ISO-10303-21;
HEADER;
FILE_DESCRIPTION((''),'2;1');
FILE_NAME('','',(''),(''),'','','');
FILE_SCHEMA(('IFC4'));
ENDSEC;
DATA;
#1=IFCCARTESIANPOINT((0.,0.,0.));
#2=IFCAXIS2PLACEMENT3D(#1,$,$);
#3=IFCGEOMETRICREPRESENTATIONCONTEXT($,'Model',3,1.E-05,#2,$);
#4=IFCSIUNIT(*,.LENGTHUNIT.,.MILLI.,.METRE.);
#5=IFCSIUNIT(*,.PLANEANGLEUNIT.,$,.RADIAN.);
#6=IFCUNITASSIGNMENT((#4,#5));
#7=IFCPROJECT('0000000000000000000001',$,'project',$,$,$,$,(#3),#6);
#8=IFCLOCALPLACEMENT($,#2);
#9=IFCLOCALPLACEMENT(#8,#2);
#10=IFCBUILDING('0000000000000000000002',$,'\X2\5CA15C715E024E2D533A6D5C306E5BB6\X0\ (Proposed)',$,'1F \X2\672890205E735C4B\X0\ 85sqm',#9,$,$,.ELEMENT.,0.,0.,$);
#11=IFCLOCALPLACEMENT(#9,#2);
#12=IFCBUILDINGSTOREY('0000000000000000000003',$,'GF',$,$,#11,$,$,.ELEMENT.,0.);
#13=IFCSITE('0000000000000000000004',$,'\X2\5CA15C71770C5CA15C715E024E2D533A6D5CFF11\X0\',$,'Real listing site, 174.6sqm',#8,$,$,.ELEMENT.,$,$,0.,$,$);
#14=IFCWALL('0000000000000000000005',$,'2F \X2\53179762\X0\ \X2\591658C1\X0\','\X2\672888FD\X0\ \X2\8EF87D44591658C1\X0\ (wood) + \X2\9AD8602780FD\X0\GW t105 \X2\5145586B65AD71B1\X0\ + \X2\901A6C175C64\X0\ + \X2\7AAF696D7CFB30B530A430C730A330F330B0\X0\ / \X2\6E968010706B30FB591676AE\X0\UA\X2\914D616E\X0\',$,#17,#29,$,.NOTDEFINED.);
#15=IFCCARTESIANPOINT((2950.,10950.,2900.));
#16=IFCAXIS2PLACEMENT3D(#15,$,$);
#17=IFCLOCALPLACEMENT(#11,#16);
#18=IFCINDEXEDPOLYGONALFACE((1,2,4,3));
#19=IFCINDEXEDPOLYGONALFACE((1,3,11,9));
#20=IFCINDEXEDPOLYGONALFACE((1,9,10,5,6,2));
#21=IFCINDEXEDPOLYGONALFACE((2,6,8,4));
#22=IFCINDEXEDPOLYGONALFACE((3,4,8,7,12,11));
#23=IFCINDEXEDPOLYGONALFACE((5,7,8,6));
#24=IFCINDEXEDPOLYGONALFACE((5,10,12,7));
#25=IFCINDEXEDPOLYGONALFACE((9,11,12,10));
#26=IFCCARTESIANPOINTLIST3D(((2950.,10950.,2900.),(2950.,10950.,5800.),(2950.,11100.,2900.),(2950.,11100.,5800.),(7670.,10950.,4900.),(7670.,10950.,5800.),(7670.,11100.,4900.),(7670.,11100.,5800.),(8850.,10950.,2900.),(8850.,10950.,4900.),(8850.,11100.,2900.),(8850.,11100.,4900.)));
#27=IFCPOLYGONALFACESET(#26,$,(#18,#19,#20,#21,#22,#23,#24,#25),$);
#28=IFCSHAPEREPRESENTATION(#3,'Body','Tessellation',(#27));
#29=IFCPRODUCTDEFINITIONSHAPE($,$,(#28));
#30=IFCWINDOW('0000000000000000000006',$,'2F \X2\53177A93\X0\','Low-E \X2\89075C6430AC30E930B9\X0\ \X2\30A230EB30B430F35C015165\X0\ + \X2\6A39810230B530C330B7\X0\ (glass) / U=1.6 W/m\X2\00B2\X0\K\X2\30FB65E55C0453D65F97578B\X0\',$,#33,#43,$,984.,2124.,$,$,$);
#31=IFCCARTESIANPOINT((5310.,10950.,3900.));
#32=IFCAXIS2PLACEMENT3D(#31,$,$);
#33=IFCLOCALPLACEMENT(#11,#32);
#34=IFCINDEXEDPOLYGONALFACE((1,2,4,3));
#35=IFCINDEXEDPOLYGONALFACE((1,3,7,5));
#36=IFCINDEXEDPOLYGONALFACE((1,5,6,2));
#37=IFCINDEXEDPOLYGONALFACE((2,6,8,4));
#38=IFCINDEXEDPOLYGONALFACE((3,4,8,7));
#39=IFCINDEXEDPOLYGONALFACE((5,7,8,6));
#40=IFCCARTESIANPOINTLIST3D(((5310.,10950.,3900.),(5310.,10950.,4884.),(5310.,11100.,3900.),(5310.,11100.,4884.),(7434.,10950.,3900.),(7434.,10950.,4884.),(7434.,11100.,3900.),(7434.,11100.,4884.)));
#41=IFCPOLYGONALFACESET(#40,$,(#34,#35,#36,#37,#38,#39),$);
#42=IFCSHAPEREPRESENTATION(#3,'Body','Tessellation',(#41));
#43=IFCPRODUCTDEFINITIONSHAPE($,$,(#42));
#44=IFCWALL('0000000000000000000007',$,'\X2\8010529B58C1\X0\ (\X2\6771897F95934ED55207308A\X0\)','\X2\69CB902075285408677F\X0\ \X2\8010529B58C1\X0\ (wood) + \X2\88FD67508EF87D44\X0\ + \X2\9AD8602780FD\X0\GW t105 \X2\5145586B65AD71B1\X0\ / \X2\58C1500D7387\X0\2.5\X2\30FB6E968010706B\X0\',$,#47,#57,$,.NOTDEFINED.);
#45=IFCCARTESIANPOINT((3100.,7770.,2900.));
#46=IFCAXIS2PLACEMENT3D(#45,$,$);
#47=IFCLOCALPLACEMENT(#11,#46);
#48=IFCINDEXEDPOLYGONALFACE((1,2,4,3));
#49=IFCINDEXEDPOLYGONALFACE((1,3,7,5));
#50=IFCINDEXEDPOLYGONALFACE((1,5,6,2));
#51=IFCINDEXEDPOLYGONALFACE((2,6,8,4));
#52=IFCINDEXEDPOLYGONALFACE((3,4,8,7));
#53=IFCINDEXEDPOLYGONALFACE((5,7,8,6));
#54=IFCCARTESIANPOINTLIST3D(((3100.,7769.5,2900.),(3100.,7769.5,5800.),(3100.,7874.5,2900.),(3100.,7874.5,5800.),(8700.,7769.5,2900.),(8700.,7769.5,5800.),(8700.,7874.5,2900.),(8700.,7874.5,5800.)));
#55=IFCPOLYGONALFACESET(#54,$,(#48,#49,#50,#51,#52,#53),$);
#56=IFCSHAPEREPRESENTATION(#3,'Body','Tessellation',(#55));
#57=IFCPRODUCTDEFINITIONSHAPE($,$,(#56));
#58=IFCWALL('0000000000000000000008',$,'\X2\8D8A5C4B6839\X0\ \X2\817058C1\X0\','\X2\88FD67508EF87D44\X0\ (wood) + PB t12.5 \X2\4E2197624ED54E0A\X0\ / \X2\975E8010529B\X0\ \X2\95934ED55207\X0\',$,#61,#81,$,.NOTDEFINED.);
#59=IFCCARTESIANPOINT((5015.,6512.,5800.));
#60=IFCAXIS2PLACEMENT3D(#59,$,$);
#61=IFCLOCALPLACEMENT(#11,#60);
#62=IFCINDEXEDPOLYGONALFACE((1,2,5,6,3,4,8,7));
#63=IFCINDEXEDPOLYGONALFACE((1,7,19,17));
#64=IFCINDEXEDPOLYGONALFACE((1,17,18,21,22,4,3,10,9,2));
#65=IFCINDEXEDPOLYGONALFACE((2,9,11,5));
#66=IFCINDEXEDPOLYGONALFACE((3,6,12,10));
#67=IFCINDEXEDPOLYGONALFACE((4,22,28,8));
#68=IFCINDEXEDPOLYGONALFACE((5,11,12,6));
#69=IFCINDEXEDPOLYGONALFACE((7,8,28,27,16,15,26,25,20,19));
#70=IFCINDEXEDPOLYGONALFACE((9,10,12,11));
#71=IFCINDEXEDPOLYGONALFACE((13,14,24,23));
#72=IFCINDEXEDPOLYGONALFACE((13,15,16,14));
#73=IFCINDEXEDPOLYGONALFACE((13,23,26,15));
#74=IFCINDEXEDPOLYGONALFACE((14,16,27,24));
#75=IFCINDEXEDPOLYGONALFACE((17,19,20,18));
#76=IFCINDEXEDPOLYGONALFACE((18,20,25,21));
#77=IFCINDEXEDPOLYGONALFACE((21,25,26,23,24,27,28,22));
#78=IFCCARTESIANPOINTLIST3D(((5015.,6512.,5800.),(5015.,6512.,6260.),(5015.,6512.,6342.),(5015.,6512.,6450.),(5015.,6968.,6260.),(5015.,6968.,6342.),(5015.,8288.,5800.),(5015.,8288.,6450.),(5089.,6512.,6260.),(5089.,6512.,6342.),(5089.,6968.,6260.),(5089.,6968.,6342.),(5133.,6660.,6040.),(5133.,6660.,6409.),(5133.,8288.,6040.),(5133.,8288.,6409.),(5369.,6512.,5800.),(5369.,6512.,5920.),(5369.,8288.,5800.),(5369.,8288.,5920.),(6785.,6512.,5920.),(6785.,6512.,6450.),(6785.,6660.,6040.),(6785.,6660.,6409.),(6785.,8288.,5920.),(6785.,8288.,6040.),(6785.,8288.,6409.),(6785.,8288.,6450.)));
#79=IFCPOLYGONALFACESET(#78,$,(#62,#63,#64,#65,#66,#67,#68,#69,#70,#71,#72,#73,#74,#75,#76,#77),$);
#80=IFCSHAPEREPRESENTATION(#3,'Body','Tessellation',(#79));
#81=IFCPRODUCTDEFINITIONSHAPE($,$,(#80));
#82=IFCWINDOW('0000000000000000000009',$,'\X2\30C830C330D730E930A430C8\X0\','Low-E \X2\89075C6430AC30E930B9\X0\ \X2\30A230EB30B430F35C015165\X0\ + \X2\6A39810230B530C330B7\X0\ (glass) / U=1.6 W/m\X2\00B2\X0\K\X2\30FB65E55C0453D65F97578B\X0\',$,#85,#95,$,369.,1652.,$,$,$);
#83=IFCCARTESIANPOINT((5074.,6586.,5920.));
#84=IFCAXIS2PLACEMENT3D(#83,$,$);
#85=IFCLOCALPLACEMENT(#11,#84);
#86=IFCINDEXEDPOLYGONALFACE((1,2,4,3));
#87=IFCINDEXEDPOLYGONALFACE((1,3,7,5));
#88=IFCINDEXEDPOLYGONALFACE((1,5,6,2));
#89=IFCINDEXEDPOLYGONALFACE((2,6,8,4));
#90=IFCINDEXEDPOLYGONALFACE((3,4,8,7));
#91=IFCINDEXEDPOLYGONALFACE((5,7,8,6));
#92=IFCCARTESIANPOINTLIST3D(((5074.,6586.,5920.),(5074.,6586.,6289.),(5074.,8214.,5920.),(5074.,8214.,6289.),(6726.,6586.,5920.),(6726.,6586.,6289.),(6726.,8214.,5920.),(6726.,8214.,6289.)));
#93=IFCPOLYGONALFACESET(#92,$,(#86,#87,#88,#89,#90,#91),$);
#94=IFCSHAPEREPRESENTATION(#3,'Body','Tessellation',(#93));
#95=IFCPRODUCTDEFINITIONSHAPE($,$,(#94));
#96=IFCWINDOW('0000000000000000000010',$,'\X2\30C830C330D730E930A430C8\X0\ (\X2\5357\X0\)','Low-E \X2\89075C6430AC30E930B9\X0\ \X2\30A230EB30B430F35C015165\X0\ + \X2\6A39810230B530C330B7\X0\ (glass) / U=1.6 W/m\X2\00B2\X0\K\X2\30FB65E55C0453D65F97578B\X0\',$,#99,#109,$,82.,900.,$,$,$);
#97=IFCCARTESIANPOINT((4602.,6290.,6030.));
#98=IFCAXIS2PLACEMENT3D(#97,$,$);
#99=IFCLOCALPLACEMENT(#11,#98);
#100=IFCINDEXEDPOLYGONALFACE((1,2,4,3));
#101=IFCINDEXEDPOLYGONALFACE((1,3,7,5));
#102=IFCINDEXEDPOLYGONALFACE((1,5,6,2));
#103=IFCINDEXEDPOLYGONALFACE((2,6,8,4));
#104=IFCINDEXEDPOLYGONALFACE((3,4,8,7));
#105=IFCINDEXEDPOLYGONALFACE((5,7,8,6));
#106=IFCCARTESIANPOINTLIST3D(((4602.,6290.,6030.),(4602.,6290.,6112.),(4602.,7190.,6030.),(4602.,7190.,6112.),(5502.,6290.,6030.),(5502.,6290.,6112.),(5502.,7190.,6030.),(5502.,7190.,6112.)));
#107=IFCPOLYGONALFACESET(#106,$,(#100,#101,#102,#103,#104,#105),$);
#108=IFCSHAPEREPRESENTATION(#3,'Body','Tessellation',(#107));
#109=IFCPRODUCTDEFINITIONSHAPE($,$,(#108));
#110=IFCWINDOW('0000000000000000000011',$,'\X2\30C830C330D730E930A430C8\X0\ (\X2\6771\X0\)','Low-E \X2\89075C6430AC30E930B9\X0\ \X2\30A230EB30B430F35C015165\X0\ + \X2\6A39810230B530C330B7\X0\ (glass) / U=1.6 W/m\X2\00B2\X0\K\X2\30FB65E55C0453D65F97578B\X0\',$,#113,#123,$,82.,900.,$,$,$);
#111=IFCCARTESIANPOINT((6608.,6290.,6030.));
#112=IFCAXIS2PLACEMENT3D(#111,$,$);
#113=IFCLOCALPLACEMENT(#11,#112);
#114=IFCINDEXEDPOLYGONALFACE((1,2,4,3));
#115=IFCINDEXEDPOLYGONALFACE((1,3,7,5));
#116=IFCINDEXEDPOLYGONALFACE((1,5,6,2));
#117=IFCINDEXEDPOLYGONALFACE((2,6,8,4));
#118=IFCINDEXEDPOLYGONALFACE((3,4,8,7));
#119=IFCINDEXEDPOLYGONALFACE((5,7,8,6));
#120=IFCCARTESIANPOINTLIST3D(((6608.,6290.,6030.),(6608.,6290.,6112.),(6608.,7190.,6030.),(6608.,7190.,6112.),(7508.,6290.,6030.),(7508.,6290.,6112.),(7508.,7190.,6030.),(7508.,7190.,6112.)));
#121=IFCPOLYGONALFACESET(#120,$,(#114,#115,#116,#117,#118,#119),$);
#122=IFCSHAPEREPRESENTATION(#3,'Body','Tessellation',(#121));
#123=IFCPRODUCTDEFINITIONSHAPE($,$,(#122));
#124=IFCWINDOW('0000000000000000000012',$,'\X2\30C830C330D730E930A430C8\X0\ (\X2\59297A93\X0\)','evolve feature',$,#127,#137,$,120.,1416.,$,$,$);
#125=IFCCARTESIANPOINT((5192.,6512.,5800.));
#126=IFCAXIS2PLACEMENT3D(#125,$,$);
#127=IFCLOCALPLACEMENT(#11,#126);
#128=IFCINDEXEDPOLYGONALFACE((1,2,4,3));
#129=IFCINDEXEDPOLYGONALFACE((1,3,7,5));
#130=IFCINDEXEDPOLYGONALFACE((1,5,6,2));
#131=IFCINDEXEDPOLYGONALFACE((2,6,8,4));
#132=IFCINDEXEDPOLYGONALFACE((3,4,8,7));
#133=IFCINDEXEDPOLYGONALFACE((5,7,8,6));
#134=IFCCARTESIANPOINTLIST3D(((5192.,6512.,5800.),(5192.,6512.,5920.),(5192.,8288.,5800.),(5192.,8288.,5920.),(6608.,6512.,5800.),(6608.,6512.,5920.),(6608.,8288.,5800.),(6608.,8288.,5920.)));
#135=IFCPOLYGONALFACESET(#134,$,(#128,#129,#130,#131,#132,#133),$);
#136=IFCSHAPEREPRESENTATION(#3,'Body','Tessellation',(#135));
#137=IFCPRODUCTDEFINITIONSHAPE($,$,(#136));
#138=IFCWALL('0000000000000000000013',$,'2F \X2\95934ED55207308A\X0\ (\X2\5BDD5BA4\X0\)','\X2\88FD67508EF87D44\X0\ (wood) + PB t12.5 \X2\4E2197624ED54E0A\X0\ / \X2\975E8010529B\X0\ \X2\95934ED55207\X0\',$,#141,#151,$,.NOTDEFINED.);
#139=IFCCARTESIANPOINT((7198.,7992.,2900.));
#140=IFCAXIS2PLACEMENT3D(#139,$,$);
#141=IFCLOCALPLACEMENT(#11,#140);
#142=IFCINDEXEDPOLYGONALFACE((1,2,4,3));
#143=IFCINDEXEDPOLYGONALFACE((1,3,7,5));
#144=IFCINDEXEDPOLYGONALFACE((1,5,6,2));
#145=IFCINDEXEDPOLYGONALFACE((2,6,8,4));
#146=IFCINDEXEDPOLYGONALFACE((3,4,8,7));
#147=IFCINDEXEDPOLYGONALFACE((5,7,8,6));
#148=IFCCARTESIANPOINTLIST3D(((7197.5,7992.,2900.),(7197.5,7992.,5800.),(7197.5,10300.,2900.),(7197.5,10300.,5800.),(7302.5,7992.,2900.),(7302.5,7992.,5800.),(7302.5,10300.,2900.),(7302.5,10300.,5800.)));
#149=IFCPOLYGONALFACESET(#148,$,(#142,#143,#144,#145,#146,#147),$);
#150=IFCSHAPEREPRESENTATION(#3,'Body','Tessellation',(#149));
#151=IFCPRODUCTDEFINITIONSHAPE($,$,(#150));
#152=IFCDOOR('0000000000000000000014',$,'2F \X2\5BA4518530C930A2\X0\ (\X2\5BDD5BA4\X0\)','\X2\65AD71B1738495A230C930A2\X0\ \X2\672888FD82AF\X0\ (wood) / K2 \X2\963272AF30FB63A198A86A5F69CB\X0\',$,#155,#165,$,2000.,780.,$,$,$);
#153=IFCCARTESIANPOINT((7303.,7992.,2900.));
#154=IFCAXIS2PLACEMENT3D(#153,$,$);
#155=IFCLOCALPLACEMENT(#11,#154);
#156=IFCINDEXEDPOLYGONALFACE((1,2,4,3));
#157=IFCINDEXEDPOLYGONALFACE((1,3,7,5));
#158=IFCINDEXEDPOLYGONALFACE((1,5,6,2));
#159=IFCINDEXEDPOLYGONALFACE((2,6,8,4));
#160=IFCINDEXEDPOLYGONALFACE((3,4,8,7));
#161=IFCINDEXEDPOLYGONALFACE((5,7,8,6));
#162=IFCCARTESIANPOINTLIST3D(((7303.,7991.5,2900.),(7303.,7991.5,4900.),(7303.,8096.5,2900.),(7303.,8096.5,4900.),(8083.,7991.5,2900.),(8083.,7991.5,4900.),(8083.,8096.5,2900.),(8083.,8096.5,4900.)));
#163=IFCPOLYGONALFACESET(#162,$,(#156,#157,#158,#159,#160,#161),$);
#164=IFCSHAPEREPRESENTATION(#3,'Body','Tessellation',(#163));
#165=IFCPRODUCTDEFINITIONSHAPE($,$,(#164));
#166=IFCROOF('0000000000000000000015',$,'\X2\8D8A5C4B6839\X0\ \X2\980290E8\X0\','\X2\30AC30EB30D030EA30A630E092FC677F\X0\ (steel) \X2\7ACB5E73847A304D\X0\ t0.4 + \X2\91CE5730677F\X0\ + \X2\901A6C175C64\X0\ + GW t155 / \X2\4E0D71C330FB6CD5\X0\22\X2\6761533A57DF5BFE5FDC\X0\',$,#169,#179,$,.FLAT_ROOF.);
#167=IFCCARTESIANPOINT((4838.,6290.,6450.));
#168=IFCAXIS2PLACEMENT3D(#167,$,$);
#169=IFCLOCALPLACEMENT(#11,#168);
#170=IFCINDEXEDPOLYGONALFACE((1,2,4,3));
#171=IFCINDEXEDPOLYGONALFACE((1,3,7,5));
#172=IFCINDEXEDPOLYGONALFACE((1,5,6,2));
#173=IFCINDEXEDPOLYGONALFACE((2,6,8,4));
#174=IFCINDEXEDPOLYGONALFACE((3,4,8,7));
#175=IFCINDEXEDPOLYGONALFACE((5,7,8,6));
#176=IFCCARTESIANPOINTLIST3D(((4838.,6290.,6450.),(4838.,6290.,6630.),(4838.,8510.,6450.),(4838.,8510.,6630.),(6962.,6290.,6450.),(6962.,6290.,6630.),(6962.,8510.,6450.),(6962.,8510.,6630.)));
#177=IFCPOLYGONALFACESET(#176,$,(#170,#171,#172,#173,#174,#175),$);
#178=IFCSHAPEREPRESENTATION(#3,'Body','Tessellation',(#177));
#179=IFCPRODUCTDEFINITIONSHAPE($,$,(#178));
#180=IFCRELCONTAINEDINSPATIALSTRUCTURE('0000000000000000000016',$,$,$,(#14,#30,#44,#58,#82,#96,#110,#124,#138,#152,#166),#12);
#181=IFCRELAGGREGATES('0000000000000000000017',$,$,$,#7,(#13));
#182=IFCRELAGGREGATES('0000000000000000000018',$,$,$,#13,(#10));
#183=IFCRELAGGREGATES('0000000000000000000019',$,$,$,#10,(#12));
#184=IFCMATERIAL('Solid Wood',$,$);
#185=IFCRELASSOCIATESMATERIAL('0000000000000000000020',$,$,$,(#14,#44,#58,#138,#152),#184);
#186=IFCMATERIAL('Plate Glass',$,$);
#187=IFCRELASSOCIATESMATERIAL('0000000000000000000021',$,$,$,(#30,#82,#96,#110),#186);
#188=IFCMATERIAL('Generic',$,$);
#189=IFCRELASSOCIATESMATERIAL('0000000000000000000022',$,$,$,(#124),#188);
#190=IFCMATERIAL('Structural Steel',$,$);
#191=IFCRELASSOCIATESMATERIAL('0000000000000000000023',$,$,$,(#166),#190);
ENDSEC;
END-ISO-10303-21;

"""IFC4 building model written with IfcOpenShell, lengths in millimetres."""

from ifc_helpers import new_model, si_unit, frame, frame_2d, origin, place, context, project, spatial, rectangle, extrude, material, element, fill, save


model = new_model("IFC4")

# Units and contexts
model_context = context("Model", 3, precision=1e-05, world=origin())
ifc_project = project(units=[si_unit("LENGTHUNIT", "METRE", prefix="MILLI"), si_unit("PLANEANGLEUNIT", "RADIAN")], contexts=[model_context])

# Site, building, storey
site_placement = place(None, origin())
site = spatial("IfcSite", under=ifc_project, at=site_placement, Name="岡山県岡山市中区浜１", ObjectType="Real listing site, 174.6sqm", CompositionType="ELEMENT", RefElevation=0.0)
building_placement = place(site_placement, origin())
building = spatial("IfcBuilding", under=site, at=building_placement, Name="岡山市中区浜の家 (Proposed)", ObjectType="1F 木造平屋 85sqm", CompositionType="ELEMENT", ElevationOfRefHeight=0.0, ElevationOfTerrain=0.0)
storey_placement = place(building_placement, origin())
storey = spatial("IfcBuildingStorey", under=building, at=storey_placement, Name="GF", CompositionType="ELEMENT", Elevation=0.0)

# Wall, opening, window
ifc_material_1 = material(Name="Solid Wood")
wall_1_placement = place(storey_placement, frame((2950.0, 10950.0, 2900.0)))
wall_1 = element("IfcWall", 1, at=wall_1_placement, inside=storey, material=ifc_material_1, Name="2F 北面 外壁", Description="木製 軸組外壁 (wood) + 高性能GW t105 充填断熱 + 通気層 + 窯業系サイディング / 準耐火・外皮UA配慮", PredefinedType="NOTDEFINED", context=model_context, shape_type="SweptSolid", body=[
    extrude(rectangle(XDim=5900.0, YDim=150.0, at=frame_2d((2950.0, 75.0))), frame((2950.0, 10950.0, 2900.0)), (0.0, 0.0, 1.0), 2900.0),
])
opening_1_placement = place(storey_placement, frame((5310.0, 10950.0, 3900.0)))
opening_1 = element("IfcOpeningElement", 2, at=opening_1_placement, cuts=wall_1, PredefinedType="NOTDEFINED", context=model_context, shape_type="SweptSolid", body=[
    extrude(rectangle(XDim=2124.0, YDim=150.0, at=frame_2d((1062.0, 75.0))), frame((5310.0, 10950.0, 3900.0)), (0.0, 0.0, 1.0), 984.0),
])
ifc_material_2 = material(Name="Plate Glass")
window_1_placement = place(storey_placement, frame((5310.0, 10950.0, 3900.0)))
window_1 = element("IfcWindow", 3, at=window_1_placement, inside=storey, material=ifc_material_2, Name="2F 北窓", Description="Low-E 複層ガラス アルゴン封入 + 樹脂サッシ (glass) / U=1.6 W/m²K・日射取得型", OverallHeight=984.0, OverallWidth=2124.0, context=model_context, shape_type="SweptSolid", body=[
    extrude(rectangle(XDim=2124.0, YDim=150.0, at=frame_2d((1062.0, 75.0))), frame((5310.0, 10950.0, 3900.0)), (0.0, 0.0, 1.0), 984.0),
])
fill(opening_1, window_1)

# Wall
wall_2_placement = place(storey_placement, frame((3100.0, 7770.0, 2900.0)))
element("IfcWall", 4, at=wall_2_placement, inside=storey, material=ifc_material_1, Name="耐力壁 (東西間仕切り)", Description="構造用合板 耐力壁 (wood) + 製材軸組 + 高性能GW t105 充填断熱 / 壁倍率2.5・準耐火", PredefinedType="NOTDEFINED", context=model_context, shape_type="SweptSolid", body=[
    extrude(rectangle(XDim=5600.0, YDim=105.0, at=frame_2d((2800.0, 52.0))), frame((3100.0, 7770.0, 2900.0)), (0.0, 0.0, 1.0), 2900.0),
])

# Wall, openings, windows
wall_3_placement = place(storey_placement, frame((5015.0, 6512.0, 5800.0)))
wall_3 = element("IfcWall", 5, at=wall_3_placement, inside=storey, material=ifc_material_1, Name="越屋根 腰壁", Description="製材軸組 (wood) + PB t12.5 両面仕上 / 非耐力 間仕切", PredefinedType="NOTDEFINED", context=model_context, shape_type="SweptSolid", body=[
    extrude(rectangle(XDim=1770.0, YDim=1776.0, at=frame_2d((885.0, 888.0))), frame((5015.0, 6512.0, 5800.0)), (0.0, 0.0, 1.0), 650.0),
])
opening_2_placement = place(storey_placement, frame((5074.0, 6586.0, 5920.0)))
opening_2 = element("IfcOpeningElement", 6, at=opening_2_placement, cuts=wall_3, PredefinedType="NOTDEFINED", context=model_context, shape_type="SweptSolid", body=[
    extrude(rectangle(XDim=1652.0, YDim=1628.0, at=frame_2d((826.0, 814.0))), frame((5074.0, 6586.0, 5920.0)), (0.0, 0.0, 1.0), 369.0),
])
opening_3_placement = place(storey_placement, frame((4602.0, 6290.0, 6030.0)))
opening_3 = element("IfcOpeningElement", 7, at=opening_3_placement, cuts=wall_3, PredefinedType="NOTDEFINED", context=model_context, shape_type="SweptSolid", body=[
    extrude(rectangle(XDim=900.0, YDim=900.0, at=frame_2d((450.0, 450.0))), frame((4602.0, 6290.0, 6030.0)), (0.0, 0.0, 1.0), 82.0),
])
opening_4_placement = place(storey_placement, frame((6608.0, 6290.0, 6030.0)))
opening_4 = element("IfcOpeningElement", 8, at=opening_4_placement, cuts=wall_3, PredefinedType="NOTDEFINED", context=model_context, shape_type="SweptSolid", body=[
    extrude(rectangle(XDim=900.0, YDim=900.0, at=frame_2d((450.0, 450.0))), frame((6608.0, 6290.0, 6030.0)), (0.0, 0.0, 1.0), 82.0),
])
opening_5_placement = place(storey_placement, frame((5192.0, 6512.0, 5800.0)))
opening_5 = element("IfcOpeningElement", 9, at=opening_5_placement, cuts=wall_3, PredefinedType="NOTDEFINED", context=model_context, shape_type="SweptSolid", body=[
    extrude(rectangle(XDim=1416.0, YDim=1776.0, at=frame_2d((708.0, 888.0))), frame((5192.0, 6512.0, 5800.0)), (0.0, 0.0, 1.0), 120.0),
])
window_2_placement = place(storey_placement, frame((5074.0, 6586.0, 5920.0)))
window_2 = element("IfcWindow", 10, at=window_2_placement, inside=storey, material=ifc_material_2, Name="トップライト", Description="Low-E 複層ガラス アルゴン封入 + 樹脂サッシ (glass) / U=1.6 W/m²K・日射取得型", OverallHeight=369.0, OverallWidth=1652.0, context=model_context, shape_type="SweptSolid", body=[
    extrude(rectangle(XDim=1652.0, YDim=1628.0, at=frame_2d((826.0, 814.0))), frame((5074.0, 6586.0, 5920.0)), (0.0, 0.0, 1.0), 369.0),
])
fill(opening_2, window_2)
window_3_placement = place(storey_placement, frame((4602.0, 6290.0, 6030.0)))
window_3 = element("IfcWindow", 11, at=window_3_placement, inside=storey, material=ifc_material_2, Name="トップライト (南)", Description="Low-E 複層ガラス アルゴン封入 + 樹脂サッシ (glass) / U=1.6 W/m²K・日射取得型", OverallHeight=82.0, OverallWidth=900.0, context=model_context, shape_type="SweptSolid", body=[
    extrude(rectangle(XDim=900.0, YDim=900.0, at=frame_2d((450.0, 450.0))), frame((4602.0, 6290.0, 6030.0)), (0.0, 0.0, 1.0), 82.0),
])
fill(opening_3, window_3)
window_4_placement = place(storey_placement, frame((6608.0, 6290.0, 6030.0)))
window_4 = element("IfcWindow", 12, at=window_4_placement, inside=storey, material=ifc_material_2, Name="トップライト (東)", Description="Low-E 複層ガラス アルゴン封入 + 樹脂サッシ (glass) / U=1.6 W/m²K・日射取得型", OverallHeight=82.0, OverallWidth=900.0, context=model_context, shape_type="SweptSolid", body=[
    extrude(rectangle(XDim=900.0, YDim=900.0, at=frame_2d((450.0, 450.0))), frame((6608.0, 6290.0, 6030.0)), (0.0, 0.0, 1.0), 82.0),
])
fill(opening_4, window_4)
ifc_material_3 = material(Name="Generic")
window_5_placement = place(storey_placement, frame((5192.0, 6512.0, 5800.0)))
window_5 = element("IfcWindow", 13, at=window_5_placement, inside=storey, material=ifc_material_3, Name="トップライト (天窓)", Description="evolve feature", OverallHeight=120.0, OverallWidth=1416.0, context=model_context, shape_type="SweptSolid", body=[
    extrude(rectangle(XDim=1416.0, YDim=1776.0, at=frame_2d((708.0, 888.0))), frame((5192.0, 6512.0, 5800.0)), (0.0, 0.0, 1.0), 120.0),
])
fill(opening_5, window_5)

# Wall
wall_4_placement = place(storey_placement, frame((7198.0, 7992.0, 2900.0)))
element("IfcWall", 14, at=wall_4_placement, inside=storey, material=ifc_material_1, Name="2F 間仕切り (寝室)", Description="製材軸組 (wood) + PB t12.5 両面仕上 / 非耐力 間仕切", PredefinedType="NOTDEFINED", context=model_context, shape_type="SweptSolid", body=[
    extrude(rectangle(XDim=105.0, YDim=2308.0, at=frame_2d((52.0, 1154.0))), frame((7198.0, 7992.0, 2900.0)), (0.0, 0.0, 1.0), 2900.0),
])

# Door
door_placement = place(storey_placement, frame((7303.0, 7992.0, 2900.0)))
element("IfcDoor", 15, at=door_placement, inside=storey, material=ifc_material_1, Name="2F 室内ドア (寝室)", Description="断熱玄関ドア 木製芯 (wood) / K2 防犯・採風機構", OverallHeight=2000.0, OverallWidth=780.0, context=model_context, shape_type="SweptSolid", body=[
    extrude(rectangle(XDim=780.0, YDim=105.0, at=frame_2d((390.0, 52.0))), frame((7303.0, 7992.0, 2900.0)), (0.0, 0.0, 1.0), 2000.0),
])

# Roof
ifc_material_4 = material(Name="Structural Steel")
roof_placement = place(storey_placement, frame((4838.0, 6290.0, 6450.0)))
element("IfcRoof", 16, at=roof_placement, inside=storey, material=ifc_material_4, Name="越屋根 頂部", Description="ガルバリウム鋼板 (steel) 立平葺き t0.4 + 野地板 + 通気層 + GW t155 / 不燃・法22条区域対応", PredefinedType="FLAT_ROOF", context=model_context, shape_type="SweptSolid", body=[
    extrude(rectangle(XDim=2124.0, YDim=2220.0, at=frame_2d((1062.0, 1110.0))), frame((4838.0, 6290.0, 6450.0)), (0.0, 0.0, 1.0), 180.0),
])

save(model, "model.ifc")
